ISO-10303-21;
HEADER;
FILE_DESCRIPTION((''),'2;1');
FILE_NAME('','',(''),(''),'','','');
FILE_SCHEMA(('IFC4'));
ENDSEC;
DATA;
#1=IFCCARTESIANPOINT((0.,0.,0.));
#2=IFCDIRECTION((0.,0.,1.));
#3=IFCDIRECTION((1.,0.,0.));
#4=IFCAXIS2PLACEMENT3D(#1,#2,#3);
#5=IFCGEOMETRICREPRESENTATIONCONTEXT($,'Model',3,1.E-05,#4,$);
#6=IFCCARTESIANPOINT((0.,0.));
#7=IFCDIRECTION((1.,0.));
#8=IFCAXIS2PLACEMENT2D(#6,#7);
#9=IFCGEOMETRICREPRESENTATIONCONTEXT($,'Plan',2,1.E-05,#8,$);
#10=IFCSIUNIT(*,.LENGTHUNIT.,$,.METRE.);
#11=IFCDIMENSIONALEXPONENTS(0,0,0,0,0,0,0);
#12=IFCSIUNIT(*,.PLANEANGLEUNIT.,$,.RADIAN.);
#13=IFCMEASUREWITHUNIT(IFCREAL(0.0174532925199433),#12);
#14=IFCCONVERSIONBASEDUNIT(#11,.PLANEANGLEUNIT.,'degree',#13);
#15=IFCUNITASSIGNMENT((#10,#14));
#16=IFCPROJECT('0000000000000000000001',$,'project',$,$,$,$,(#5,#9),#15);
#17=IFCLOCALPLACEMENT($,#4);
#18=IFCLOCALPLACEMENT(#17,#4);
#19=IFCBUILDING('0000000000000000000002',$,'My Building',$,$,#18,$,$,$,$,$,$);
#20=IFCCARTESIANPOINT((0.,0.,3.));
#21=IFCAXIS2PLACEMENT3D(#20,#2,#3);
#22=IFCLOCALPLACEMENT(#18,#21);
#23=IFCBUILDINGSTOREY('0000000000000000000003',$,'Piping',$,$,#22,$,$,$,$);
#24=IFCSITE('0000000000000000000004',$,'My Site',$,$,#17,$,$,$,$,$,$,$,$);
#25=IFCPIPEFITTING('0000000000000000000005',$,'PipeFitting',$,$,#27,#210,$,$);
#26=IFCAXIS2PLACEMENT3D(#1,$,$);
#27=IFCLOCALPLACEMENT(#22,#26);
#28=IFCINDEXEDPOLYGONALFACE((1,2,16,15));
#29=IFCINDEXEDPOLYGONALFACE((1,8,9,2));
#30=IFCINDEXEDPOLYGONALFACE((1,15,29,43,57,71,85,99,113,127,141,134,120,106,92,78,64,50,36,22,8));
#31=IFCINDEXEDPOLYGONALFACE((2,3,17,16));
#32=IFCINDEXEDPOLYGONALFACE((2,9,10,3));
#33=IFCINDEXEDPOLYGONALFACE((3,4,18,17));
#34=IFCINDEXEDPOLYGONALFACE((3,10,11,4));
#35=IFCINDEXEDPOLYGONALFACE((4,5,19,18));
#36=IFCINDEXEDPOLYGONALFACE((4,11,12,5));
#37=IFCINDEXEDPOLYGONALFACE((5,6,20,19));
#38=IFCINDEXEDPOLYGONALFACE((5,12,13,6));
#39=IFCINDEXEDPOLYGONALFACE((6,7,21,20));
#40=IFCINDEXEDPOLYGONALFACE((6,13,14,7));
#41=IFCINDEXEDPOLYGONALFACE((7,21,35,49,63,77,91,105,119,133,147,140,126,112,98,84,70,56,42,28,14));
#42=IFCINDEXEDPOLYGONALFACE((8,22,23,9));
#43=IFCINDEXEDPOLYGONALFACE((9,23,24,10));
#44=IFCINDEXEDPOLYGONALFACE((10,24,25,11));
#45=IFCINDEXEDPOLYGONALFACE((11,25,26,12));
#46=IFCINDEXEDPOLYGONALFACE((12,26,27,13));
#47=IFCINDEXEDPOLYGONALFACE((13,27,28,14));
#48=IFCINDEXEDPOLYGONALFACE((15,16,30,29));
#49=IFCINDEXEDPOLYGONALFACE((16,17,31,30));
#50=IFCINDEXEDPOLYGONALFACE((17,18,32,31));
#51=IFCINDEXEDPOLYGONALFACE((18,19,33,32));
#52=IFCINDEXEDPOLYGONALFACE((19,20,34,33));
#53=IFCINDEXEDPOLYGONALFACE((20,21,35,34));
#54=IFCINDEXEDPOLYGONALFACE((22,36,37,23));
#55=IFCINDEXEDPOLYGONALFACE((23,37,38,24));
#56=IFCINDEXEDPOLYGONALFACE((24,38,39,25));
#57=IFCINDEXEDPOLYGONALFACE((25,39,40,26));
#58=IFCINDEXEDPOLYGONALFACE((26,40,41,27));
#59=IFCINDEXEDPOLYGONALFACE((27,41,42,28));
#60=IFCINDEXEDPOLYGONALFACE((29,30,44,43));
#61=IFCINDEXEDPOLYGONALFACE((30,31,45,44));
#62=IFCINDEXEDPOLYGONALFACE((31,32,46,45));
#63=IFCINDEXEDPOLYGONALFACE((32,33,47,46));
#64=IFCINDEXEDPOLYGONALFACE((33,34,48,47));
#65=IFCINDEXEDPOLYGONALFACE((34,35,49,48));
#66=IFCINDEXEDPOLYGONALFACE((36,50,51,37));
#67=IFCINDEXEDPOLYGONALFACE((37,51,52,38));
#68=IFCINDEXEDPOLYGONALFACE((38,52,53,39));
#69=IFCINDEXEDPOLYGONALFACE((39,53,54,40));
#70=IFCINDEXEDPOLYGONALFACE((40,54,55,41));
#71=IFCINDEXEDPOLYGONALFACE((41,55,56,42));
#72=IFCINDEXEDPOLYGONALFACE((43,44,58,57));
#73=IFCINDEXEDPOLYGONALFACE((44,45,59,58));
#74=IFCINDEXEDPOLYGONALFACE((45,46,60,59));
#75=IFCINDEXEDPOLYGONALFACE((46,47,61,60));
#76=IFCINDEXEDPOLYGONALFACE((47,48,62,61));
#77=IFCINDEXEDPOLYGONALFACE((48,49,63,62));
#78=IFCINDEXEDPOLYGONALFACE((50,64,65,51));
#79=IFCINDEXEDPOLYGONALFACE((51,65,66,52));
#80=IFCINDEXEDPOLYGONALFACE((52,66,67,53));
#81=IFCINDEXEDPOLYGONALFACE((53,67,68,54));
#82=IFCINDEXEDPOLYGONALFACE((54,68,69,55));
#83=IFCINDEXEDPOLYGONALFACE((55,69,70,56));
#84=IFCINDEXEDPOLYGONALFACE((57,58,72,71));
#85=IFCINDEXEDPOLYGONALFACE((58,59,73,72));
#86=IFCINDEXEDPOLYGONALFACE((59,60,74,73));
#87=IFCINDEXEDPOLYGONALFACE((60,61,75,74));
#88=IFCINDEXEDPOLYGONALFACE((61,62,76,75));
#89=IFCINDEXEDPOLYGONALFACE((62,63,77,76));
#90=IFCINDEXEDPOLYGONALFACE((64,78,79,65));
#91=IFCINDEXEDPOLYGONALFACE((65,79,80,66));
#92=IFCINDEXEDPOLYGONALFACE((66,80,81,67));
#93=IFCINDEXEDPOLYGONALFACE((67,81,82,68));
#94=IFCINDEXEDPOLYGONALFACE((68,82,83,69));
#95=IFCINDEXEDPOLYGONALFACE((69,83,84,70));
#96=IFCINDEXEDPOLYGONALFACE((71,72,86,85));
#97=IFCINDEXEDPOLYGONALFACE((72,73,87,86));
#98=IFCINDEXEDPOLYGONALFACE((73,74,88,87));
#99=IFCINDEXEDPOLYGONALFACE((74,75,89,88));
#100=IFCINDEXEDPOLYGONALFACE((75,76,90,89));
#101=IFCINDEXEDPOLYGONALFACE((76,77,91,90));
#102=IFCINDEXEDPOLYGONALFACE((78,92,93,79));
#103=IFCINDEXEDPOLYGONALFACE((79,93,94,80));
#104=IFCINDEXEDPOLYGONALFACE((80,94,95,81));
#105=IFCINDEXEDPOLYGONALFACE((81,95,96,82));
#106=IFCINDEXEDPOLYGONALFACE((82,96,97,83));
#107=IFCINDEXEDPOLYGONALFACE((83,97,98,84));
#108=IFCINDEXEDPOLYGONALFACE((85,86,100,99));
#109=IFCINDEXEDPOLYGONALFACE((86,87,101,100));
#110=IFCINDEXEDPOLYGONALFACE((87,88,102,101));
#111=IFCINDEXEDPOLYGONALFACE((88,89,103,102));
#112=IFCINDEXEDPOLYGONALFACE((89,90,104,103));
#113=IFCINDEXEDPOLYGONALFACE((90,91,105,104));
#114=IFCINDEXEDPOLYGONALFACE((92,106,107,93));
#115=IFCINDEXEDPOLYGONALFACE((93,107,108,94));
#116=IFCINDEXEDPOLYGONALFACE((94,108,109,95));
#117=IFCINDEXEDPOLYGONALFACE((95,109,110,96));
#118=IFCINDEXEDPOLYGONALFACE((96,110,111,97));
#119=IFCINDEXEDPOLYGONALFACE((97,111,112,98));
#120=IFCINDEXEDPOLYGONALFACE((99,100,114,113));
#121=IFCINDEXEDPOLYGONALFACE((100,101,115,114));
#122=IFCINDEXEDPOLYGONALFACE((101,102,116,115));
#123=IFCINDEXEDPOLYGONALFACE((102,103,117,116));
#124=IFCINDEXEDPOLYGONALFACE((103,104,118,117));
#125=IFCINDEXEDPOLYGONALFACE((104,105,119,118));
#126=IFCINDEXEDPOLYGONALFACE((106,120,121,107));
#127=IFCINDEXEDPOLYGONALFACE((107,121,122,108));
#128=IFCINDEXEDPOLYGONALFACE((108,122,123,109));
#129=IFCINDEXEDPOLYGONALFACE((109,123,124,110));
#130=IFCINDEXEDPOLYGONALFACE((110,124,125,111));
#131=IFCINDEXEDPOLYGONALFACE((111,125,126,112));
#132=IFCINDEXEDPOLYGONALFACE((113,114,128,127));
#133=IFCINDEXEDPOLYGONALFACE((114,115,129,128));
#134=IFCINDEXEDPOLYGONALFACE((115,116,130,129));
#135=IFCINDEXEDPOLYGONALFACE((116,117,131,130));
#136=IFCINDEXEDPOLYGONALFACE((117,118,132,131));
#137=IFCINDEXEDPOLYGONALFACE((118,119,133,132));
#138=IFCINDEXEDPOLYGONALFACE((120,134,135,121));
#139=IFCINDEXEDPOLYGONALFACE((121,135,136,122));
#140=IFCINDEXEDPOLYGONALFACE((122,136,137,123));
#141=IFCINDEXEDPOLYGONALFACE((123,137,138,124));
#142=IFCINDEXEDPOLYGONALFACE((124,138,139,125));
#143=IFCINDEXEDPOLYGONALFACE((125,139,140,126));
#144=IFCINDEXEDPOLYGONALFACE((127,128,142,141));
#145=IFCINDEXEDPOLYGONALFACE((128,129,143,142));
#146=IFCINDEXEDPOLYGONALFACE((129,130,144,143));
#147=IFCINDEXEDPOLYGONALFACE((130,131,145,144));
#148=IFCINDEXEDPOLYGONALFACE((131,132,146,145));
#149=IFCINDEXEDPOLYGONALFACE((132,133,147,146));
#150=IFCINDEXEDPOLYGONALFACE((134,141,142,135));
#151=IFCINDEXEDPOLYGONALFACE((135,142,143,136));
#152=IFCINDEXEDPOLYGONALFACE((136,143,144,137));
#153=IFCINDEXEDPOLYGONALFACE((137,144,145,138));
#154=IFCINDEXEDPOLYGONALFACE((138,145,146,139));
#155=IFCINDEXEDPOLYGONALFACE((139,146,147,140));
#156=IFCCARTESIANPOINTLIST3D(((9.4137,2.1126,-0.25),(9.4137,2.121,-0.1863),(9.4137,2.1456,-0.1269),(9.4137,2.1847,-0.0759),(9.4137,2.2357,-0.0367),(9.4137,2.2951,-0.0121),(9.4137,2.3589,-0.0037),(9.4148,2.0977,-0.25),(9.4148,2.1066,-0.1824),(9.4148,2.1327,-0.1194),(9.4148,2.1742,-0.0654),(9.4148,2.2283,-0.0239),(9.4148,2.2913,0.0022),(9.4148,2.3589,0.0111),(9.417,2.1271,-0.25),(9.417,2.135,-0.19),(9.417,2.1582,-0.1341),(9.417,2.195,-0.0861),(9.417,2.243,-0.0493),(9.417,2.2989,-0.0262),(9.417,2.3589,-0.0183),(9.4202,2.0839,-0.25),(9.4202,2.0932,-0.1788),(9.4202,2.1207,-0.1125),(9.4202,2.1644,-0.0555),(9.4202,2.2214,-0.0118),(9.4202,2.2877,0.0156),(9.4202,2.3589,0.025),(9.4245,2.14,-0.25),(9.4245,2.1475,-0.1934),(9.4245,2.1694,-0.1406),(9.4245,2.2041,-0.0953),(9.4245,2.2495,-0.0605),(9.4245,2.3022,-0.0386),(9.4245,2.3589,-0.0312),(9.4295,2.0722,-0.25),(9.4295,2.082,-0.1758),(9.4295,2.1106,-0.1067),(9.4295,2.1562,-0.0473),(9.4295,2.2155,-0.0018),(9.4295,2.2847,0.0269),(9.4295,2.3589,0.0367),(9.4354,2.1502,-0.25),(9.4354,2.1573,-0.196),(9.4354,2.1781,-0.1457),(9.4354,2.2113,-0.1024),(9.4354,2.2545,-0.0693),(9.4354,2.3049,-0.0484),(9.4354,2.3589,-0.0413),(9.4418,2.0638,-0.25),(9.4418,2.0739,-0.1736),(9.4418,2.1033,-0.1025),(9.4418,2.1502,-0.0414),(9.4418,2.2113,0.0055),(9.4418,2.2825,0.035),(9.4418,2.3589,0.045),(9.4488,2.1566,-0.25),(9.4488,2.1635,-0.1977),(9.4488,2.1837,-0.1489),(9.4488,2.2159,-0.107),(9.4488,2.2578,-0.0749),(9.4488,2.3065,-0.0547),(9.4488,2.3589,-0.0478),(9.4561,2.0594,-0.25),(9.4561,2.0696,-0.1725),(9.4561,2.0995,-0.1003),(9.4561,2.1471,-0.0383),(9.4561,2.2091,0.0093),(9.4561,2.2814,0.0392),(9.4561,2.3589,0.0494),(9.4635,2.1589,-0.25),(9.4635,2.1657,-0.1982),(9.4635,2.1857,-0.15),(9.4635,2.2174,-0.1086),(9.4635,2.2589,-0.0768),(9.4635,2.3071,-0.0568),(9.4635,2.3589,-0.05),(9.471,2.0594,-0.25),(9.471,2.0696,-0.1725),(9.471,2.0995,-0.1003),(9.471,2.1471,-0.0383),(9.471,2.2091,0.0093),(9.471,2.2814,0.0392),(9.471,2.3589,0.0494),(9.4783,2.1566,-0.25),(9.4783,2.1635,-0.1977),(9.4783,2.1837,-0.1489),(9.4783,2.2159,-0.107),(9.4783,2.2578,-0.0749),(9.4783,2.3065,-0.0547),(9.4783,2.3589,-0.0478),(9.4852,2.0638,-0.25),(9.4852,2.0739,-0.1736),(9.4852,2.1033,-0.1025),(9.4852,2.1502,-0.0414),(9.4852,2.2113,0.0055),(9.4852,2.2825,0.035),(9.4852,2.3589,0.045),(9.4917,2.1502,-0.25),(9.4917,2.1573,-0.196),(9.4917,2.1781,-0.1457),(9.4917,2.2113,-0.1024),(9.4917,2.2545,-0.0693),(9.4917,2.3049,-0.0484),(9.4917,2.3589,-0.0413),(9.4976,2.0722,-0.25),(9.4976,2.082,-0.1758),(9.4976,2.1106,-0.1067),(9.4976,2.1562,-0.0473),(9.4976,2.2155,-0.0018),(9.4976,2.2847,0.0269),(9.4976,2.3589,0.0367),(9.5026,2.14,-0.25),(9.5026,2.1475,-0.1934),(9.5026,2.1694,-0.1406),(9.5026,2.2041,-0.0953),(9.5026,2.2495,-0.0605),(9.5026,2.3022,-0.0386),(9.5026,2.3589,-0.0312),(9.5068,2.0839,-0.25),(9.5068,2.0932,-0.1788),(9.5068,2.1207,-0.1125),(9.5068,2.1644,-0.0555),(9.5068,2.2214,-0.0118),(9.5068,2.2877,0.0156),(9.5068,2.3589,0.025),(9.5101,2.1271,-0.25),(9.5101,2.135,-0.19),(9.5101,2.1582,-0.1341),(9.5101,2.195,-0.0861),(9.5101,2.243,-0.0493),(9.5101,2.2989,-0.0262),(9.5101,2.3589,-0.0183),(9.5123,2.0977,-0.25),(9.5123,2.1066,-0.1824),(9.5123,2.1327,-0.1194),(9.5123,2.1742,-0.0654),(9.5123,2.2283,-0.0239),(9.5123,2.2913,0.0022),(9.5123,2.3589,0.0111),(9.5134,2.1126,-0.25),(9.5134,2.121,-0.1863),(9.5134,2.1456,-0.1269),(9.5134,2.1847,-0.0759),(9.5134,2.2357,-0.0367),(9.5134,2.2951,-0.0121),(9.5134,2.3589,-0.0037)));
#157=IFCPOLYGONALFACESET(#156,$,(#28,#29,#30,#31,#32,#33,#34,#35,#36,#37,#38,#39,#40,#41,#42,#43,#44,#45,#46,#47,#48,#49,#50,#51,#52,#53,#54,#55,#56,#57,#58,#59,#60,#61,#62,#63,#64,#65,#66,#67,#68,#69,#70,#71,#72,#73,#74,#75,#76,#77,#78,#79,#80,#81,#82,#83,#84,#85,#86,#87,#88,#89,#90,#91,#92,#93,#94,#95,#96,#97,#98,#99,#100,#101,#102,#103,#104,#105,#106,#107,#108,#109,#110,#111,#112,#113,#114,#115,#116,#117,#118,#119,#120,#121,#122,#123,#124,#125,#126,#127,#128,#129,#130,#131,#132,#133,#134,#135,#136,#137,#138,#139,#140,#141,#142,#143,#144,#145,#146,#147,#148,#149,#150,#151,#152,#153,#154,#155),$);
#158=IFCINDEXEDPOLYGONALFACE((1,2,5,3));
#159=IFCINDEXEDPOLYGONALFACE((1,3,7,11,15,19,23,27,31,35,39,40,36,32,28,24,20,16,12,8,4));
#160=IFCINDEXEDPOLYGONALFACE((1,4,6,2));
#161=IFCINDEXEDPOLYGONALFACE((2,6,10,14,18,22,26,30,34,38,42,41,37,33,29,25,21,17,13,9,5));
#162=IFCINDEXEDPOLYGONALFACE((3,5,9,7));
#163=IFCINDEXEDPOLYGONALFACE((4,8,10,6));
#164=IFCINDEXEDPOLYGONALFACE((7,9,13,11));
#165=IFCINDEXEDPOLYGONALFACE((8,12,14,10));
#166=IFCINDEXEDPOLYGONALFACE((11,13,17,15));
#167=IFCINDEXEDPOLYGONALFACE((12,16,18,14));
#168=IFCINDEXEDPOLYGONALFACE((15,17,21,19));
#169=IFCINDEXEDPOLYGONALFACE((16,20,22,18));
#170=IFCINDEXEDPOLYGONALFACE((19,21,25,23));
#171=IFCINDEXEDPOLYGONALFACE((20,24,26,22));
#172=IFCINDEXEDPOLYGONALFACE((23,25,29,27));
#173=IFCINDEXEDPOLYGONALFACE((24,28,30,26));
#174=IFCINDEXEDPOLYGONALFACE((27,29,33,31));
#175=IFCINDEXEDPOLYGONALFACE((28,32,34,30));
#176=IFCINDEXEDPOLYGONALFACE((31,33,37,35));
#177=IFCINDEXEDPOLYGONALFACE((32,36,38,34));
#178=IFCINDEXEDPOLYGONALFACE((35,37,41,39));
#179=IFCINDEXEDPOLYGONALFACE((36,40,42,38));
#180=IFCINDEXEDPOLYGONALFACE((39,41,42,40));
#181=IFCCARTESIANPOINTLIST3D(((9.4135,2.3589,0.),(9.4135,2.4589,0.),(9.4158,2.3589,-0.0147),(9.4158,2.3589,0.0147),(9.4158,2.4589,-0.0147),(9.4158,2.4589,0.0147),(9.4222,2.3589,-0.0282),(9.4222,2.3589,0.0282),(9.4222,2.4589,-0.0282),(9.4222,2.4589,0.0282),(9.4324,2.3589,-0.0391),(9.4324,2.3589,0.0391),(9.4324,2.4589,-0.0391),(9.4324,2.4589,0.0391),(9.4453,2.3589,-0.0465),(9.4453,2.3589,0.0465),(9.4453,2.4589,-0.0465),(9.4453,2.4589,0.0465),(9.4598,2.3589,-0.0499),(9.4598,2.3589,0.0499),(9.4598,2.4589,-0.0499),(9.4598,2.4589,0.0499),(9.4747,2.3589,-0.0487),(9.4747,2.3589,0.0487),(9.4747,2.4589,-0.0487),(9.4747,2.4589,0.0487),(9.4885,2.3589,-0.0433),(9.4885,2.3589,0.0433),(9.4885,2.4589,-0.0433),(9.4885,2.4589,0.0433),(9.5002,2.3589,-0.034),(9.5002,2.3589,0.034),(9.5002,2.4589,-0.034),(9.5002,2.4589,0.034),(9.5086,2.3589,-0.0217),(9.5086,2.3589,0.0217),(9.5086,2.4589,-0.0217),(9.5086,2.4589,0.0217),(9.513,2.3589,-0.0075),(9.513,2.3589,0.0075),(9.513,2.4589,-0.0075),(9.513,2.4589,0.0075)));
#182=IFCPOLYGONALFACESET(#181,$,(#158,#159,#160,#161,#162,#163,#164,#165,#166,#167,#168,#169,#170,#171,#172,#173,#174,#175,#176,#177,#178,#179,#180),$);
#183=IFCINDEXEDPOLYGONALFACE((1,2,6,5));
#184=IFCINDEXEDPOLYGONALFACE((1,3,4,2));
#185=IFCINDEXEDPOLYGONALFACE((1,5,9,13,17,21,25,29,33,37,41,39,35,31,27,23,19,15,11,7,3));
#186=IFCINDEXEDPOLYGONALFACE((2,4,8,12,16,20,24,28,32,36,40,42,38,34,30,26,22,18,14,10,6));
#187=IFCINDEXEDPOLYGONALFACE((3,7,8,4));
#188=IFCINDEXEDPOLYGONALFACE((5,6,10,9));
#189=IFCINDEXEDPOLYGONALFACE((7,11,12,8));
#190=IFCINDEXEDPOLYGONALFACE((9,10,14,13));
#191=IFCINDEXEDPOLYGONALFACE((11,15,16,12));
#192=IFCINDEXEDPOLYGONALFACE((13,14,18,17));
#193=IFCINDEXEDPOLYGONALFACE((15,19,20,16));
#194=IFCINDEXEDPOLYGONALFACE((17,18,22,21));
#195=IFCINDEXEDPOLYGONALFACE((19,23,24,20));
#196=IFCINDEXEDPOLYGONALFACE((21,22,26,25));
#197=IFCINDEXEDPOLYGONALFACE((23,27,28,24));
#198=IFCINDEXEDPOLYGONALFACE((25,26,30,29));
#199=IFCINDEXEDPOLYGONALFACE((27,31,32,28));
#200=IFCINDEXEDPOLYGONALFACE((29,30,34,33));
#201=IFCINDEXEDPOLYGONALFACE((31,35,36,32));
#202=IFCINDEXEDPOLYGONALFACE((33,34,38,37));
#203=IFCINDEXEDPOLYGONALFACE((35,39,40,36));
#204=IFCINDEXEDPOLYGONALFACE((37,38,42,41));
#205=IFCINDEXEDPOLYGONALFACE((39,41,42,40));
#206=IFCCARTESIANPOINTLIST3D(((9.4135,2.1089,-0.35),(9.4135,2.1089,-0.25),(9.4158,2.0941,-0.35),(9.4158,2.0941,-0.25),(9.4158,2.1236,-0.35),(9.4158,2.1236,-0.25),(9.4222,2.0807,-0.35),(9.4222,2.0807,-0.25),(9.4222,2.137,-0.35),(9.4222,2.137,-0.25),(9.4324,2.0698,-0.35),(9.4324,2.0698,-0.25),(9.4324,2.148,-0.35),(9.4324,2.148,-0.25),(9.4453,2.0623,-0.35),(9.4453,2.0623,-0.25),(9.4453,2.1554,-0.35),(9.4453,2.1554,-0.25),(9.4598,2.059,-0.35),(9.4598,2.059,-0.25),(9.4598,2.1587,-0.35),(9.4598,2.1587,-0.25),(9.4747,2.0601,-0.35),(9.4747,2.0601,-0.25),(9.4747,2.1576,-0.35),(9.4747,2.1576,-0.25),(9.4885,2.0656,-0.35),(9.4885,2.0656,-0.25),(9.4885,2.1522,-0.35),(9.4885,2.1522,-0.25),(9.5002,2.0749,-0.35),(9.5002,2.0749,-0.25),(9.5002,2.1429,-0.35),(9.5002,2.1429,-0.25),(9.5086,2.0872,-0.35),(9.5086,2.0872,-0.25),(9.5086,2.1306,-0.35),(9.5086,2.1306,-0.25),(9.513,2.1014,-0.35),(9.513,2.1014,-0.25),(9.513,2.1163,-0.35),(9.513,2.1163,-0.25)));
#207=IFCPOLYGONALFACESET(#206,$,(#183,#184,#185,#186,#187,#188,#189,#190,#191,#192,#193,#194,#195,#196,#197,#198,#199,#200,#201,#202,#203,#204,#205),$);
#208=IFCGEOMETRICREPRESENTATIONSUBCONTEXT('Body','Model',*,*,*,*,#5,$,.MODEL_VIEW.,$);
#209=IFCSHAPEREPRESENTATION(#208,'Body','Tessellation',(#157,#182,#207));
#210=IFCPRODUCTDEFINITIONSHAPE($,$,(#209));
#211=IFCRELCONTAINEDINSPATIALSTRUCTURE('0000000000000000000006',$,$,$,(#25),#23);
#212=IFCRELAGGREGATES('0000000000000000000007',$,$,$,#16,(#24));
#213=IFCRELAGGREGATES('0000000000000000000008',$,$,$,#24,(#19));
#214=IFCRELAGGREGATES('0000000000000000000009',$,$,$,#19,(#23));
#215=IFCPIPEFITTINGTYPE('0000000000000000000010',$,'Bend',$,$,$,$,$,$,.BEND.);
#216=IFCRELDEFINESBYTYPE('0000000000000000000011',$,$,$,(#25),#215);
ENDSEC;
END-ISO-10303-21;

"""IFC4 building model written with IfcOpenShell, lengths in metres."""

from ifc_helpers import new_model, entity, si_unit, converted_unit, frame, origin_with_axes, origin_2d_with_axis, place, context, subcontext, project, spatial, circle, extrude, source, transform, mapped, type_object, type_shapes, element, save


model = new_model("IFC4")

# Units and contexts
model_context = context("Model", 3, precision=1e-05, world=origin_with_axes())
plan_context = context("Plan", 2, precision=1e-05, world=origin_2d_with_axis())
body_context = subcontext(model_context, "Body", "Model", "MODEL_VIEW")
ifc_project = project(units=[si_unit("LENGTHUNIT", "METRE"), converted_unit("PLANEANGLEUNIT", "degree", entity("IfcReal", 0.0174532925199433), si_unit("PLANEANGLEUNIT", "RADIAN"), dimensions=[0, 0, 0, 0, 0, 0, 0])], contexts=[model_context, plan_context])

# Site, building, storey
site_placement = place(None, origin_with_axes())
site = spatial("IfcSite", under=ifc_project, at=site_placement, Name="My Site")
building_placement = place(site_placement, origin_with_axes())
building = spatial("IfcBuilding", under=site, at=building_placement, Name="My Building")
storey_placement = place(building_placement, frame((0.0, 0.0, 3.0), z_axis=(0.0, 0.0, 1.0), x_axis=(1.0, 0.0, 0.0)))
storey = spatial("IfcBuildingStorey", under=building, at=storey_placement, Name="Piping")

# Shared definitions
pipe_fitting_type = type_object("IfcPipeFittingType", Name="Bend", PredefinedType="BEND")
shared_shape = source(origin_with_axes(), body_context, "Body", "SolidModel", [
    entity("IfcSweptDiskSolid", entity("IfcIndexedPolyCurve", entity("IfcCartesianPointList3D", [[0.0, 0.0, -0.1], [0.0, -0.0732, -0.2768], [0.0, -0.25, -0.35]]), [entity("IfcArcIndex", [1, 2, 3])]), 0.05),
    extrude(circle(Radius=0.05), origin_with_axes(), (0.0, 0.0, -1.0), 0.1),
    extrude(circle(Radius=0.05), frame((0.0, -0.25, -0.35), z_axis=(0.0, -1.0, 0.0), x_axis=(1.0, 0.0, 0.0)), (0.0, 0.0, 1.0), 0.1),
])
type_shapes(pipe_fitting_type, [shared_shape])

# Pipe fitting
for number, where, z_axis, x_axis, name in (
    (1, (9.4635, 2.4589, 0.0), (0.0, 1.0, 0.0), (-1.0, 0.0, 0.0), "PipeFitting"),
):
    element("IfcPipeFitting", number, at=place(storey_placement, frame(where, z_axis=z_axis, x_axis=x_axis)), inside=storey, type_object=pipe_fitting_type, Name=name, context=body_context, shape_type="MappedRepresentation", body=[
        mapped(shared_shape, transform((0.0, 0.0, 0.0), x_axis=(1.0, 0.0, 0.0), y_axis=(0.0, 1.0, 0.0), z_axis=(0.0, 0.0, 1.0), scale=1.0)),
    ])

save(model, "model.ifc")
